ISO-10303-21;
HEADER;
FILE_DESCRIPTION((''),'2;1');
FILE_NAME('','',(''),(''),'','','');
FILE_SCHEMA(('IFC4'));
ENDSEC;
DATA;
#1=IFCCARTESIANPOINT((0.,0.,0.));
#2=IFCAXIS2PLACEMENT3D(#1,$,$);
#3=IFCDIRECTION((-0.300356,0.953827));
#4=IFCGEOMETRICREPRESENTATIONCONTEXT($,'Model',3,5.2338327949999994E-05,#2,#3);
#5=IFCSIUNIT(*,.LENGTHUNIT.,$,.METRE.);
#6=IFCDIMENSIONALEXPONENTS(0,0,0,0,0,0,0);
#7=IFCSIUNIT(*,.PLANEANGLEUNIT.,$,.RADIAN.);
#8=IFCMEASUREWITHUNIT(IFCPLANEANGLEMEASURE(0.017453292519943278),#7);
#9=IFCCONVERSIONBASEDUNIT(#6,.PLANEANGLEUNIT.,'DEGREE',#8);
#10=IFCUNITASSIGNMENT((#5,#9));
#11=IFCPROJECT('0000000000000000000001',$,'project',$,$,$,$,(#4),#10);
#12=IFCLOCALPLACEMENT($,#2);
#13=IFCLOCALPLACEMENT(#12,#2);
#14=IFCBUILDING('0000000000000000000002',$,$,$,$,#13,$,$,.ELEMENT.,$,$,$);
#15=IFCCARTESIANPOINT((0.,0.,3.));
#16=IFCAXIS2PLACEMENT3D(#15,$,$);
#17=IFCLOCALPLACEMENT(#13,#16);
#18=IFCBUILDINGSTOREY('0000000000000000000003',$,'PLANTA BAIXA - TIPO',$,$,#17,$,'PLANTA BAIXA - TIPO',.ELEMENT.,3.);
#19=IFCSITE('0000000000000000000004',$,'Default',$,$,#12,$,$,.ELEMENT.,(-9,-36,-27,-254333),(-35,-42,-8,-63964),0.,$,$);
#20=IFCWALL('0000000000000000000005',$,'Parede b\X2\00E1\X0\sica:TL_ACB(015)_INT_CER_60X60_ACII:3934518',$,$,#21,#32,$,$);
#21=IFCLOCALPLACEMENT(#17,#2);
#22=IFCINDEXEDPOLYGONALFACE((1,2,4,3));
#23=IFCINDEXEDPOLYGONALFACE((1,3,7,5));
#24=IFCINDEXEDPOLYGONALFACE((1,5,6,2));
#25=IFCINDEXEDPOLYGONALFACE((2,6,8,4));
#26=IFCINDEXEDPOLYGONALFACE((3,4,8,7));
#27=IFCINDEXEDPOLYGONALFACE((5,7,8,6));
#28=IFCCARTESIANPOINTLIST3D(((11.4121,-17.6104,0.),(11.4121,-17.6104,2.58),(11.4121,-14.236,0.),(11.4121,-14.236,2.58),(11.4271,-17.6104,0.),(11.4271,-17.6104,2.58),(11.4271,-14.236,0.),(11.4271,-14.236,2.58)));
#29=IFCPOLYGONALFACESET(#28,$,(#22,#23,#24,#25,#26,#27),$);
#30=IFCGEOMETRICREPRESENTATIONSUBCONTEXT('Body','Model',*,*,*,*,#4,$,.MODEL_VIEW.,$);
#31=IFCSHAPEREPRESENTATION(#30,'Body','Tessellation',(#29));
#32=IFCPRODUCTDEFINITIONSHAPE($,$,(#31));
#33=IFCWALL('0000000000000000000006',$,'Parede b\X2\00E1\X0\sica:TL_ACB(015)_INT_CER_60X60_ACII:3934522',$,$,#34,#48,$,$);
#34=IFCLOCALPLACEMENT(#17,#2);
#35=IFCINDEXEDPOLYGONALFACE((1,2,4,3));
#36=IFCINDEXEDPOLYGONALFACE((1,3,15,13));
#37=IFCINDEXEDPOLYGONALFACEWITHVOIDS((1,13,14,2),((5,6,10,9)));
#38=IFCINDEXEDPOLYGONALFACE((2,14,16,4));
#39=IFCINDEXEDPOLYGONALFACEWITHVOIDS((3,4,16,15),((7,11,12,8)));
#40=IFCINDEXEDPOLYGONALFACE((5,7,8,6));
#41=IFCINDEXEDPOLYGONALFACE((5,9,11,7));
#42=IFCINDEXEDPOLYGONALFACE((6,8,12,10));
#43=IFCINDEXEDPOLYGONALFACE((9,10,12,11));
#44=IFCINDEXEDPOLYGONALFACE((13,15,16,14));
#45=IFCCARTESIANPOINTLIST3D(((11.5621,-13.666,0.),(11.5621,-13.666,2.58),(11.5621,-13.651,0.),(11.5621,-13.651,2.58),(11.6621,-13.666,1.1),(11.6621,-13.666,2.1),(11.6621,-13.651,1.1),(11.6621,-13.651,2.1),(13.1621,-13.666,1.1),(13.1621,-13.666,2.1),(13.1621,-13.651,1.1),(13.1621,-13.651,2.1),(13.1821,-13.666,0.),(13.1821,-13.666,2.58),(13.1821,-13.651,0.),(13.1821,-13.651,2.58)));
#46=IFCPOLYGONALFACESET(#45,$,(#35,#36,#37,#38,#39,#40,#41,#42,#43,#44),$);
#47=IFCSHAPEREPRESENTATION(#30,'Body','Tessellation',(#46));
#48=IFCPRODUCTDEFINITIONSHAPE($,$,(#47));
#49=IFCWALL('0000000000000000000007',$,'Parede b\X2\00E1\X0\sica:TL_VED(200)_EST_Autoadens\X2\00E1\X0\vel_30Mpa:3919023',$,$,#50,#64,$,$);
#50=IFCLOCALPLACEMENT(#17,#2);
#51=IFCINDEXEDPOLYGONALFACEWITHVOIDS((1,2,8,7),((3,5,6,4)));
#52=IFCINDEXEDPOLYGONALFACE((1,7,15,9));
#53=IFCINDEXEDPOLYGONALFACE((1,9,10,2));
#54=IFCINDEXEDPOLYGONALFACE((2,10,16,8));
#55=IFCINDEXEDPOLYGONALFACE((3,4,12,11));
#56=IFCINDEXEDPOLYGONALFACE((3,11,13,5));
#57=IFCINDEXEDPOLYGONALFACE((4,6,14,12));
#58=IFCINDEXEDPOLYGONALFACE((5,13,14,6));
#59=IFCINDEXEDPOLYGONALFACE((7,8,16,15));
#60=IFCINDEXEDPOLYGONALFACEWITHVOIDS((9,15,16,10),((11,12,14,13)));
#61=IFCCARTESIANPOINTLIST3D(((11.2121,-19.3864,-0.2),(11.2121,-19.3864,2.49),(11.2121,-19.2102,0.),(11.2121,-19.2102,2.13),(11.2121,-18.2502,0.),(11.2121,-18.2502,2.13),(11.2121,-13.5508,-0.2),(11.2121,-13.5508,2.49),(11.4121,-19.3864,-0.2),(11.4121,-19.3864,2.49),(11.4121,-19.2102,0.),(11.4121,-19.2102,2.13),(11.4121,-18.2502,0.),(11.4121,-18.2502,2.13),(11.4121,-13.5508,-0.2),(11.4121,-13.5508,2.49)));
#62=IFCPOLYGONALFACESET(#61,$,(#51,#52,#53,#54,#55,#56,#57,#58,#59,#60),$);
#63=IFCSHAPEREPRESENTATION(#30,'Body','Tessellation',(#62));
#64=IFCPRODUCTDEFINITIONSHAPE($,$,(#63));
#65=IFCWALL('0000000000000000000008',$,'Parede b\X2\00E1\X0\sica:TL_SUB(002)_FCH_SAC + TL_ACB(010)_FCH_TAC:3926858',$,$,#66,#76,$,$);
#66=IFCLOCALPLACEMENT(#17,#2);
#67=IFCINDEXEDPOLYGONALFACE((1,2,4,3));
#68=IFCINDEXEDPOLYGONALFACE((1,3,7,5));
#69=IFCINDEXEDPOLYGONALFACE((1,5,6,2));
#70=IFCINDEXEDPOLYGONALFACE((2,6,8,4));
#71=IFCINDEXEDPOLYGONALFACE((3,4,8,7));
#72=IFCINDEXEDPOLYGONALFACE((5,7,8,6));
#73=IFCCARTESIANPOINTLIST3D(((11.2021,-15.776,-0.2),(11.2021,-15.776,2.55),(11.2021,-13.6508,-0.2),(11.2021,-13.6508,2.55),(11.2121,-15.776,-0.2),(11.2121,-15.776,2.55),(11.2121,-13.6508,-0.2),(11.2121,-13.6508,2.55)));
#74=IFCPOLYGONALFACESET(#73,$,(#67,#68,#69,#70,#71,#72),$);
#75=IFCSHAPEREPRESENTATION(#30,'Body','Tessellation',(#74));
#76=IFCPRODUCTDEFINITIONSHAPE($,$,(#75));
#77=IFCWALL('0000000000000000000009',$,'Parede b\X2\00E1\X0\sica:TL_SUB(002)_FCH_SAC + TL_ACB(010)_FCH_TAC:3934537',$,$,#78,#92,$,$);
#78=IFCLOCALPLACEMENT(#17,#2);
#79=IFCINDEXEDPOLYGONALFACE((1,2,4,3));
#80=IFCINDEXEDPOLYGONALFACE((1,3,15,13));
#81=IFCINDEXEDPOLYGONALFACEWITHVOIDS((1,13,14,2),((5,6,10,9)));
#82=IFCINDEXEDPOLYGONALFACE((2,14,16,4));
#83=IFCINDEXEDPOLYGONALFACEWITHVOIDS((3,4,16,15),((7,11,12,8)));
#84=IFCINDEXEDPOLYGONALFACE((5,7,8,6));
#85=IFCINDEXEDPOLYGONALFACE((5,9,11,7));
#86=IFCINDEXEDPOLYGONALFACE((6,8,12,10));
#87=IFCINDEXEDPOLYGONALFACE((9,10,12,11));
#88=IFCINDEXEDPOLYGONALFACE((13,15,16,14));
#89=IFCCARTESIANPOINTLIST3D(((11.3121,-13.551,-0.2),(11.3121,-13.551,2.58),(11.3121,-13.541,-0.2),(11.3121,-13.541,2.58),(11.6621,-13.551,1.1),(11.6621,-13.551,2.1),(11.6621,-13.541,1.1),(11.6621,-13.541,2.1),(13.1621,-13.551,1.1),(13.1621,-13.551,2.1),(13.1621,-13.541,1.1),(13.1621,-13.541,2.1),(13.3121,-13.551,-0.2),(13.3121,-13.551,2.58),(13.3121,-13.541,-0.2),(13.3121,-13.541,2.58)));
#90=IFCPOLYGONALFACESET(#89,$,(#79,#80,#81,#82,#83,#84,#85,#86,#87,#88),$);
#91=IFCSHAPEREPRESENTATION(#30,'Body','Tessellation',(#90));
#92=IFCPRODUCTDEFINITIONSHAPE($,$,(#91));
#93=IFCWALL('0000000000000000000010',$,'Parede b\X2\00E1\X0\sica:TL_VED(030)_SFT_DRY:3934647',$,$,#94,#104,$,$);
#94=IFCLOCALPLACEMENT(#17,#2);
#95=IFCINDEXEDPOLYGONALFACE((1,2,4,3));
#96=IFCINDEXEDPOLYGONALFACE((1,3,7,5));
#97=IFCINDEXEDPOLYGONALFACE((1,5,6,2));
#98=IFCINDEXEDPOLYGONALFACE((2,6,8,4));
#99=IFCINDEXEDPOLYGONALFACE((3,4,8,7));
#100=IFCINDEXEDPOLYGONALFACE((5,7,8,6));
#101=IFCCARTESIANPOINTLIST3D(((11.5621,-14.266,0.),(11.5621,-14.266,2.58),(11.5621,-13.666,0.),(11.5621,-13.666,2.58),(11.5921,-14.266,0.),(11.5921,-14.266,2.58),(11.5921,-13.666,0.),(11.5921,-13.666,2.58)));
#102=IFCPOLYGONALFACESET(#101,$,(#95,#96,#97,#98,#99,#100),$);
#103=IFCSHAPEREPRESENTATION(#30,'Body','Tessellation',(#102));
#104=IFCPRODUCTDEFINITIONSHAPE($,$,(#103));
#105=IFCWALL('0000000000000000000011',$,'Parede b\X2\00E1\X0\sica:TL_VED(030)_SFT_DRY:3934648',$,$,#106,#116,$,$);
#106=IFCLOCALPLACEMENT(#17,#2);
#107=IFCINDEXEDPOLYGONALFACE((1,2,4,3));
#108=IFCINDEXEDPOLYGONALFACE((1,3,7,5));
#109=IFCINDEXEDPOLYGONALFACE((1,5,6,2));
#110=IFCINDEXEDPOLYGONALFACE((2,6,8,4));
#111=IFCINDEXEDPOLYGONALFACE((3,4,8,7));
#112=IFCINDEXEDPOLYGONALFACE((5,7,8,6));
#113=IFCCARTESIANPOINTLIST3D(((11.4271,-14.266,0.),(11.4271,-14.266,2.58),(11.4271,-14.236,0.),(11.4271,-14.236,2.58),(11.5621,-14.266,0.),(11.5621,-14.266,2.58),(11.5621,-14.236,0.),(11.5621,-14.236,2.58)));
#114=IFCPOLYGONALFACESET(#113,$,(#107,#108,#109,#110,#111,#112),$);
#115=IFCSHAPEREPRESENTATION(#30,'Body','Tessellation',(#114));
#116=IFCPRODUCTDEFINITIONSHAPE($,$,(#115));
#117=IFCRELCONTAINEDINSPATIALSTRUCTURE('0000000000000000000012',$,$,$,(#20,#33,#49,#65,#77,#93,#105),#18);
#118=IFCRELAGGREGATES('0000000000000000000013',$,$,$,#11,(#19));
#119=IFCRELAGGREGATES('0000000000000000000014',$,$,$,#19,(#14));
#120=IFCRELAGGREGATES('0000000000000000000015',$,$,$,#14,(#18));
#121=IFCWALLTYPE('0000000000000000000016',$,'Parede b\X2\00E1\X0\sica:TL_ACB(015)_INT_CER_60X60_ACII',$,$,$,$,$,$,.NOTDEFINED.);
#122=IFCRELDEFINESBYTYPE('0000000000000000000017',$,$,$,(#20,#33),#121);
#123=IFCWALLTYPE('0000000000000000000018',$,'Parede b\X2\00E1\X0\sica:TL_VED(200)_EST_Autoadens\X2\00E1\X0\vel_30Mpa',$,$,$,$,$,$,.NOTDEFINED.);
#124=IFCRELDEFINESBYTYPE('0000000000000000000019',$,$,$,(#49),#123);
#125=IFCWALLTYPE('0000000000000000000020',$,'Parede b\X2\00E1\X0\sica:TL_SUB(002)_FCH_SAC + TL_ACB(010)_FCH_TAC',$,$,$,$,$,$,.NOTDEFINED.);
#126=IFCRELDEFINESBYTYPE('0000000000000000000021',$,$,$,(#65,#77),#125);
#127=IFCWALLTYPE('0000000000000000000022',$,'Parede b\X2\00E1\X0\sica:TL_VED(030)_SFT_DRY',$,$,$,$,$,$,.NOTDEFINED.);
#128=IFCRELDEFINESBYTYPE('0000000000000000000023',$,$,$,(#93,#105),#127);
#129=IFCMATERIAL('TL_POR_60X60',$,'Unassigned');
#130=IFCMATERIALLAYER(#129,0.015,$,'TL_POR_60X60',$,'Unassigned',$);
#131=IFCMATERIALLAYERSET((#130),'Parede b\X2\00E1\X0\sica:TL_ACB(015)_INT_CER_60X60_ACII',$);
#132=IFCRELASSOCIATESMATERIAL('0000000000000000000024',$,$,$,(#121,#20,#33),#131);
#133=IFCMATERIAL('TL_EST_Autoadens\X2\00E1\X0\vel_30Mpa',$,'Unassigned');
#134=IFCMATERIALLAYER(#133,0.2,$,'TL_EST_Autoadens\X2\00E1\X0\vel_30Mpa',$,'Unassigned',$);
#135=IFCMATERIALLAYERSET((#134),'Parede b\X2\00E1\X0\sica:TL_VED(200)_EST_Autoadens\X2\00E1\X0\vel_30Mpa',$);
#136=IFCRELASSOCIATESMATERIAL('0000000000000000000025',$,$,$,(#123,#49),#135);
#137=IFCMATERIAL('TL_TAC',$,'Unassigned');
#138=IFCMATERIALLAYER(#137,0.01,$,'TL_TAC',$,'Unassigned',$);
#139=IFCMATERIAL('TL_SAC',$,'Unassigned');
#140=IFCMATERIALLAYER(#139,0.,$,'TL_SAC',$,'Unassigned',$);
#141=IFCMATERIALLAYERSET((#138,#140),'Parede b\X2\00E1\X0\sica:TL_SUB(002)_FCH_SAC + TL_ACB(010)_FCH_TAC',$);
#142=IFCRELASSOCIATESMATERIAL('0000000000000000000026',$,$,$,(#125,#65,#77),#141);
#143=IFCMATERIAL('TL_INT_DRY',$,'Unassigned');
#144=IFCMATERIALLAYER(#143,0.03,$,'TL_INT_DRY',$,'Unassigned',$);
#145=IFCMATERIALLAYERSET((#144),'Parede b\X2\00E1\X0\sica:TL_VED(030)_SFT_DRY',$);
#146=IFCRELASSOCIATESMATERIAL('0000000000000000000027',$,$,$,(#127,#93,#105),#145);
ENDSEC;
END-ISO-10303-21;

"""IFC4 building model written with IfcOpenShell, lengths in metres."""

from ifc_helpers import new_model, entity, si_unit, converted_unit, direction, frame, frame_2d, origin, place, context, subcontext, project, spatial, rectangle, extrude, material, layer, layer_set, layer_usage, type_object, element, save


model = new_model("IFC4")

# Units and contexts
model_context = context("Model", 3, precision=5.2338327949999994e-05, world=origin(), true_north=direction((-0.300356, 0.953827)))
body_context = subcontext(model_context, "Body", "Model", "MODEL_VIEW")
ifc_project = project(units=[si_unit("LENGTHUNIT", "METRE"), converted_unit("PLANEANGLEUNIT", "DEGREE", entity("IfcPlaneAngleMeasure", 0.017453292519943278), si_unit("PLANEANGLEUNIT", "RADIAN"), dimensions=[0, 0, 0, 0, 0, 0, 0])], contexts=[model_context])

# Site, building, storey
site_placement = place(None, origin())
site = spatial("IfcSite", under=ifc_project, at=site_placement, Name="Default", CompositionType="ELEMENT", RefLatitude=(-9, -36, -27, -254333), RefLongitude=(-35, -42, -8, -63964), RefElevation=0.0)
building_placement = place(site_placement, origin())
building = spatial("IfcBuilding", under=site, at=building_placement, CompositionType="ELEMENT")
storey_placement = place(building_placement, frame((0.0, 0.0, 3.0)))
storey = spatial("IfcBuildingStorey", under=building, at=storey_placement, Name="PLANTA BAIXA - TIPO", LongName="PLANTA BAIXA - TIPO", CompositionType="ELEMENT", Elevation=3.0)

# Shared definitions
ifc_material_1 = material(Name="TL_POR_60X60", Category="Unassigned")

# Shared definitions
ifc_material_2 = material(Name="TL_EST_Autoadensável_30Mpa", Category="Unassigned")
ifc_material_3 = material(Name="TL_SAC", Category="Unassigned")

# Wall
ifc_layer_1 = layer(ifc_material_1, 0.015, Name="TL_POR_60X60", Category="Unassigned")
ifc_layer_set_1 = layer_set([ifc_layer_1], Name="Parede básica:TL_ACB(015)_INT_CER_60X60_ACII")
ifc_layer_usage_1 = layer_usage(ifc_layer_set_1, "AXIS2", "POSITIVE", -0.0075)
wall_type_1 = type_object("IfcWallType", Name="Parede básica:TL_ACB(015)_INT_CER_60X60_ACII", PredefinedType="NOTDEFINED", material=ifc_layer_set_1)
wall_1_placement = place(storey_placement, frame((11.4196, -17.6104, 0.0), z_axis=(0.0, 0.0, 1.0), x_axis=(0.0, 1.0, 0.0)))
element("IfcWall", 1, at=wall_1_placement, inside=storey, type_object=wall_type_1, material=ifc_layer_usage_1, Name="Parede básica:TL_ACB(015)_INT_CER_60X60_ACII:3934518", context=body_context, shape_type="SweptSolid", body=[
    extrude(rectangle(XDim=3.3744, YDim=0.015, at=frame_2d((1.6872, 0.0), x_axis=(-1.0, 0.0))), origin(), (0.0, 0.0, 1.0), 2.58),
])

# Walls, openings
ifc_layer_usage_2 = layer_usage(ifc_layer_set_1, "AXIS2", "POSITIVE", -0.0075)
wall_2_placement = place(storey_placement, frame((11.5621, -13.6585, 0.0)))
wall_2 = element("IfcWall", 2, at=wall_2_placement, inside=storey, type_object=wall_type_1, material=ifc_layer_usage_2, Name="Parede básica:TL_ACB(015)_INT_CER_60X60_ACII:3934522", context=body_context, shape_type="SweptSolid", body=[
    extrude(rectangle(XDim=1.62, YDim=0.015, at=frame_2d((0.81, 0.0), x_axis=(-1.0, 0.0))), origin(), (0.0, 0.0, 1.0), 2.58),
])
opening_1_placement = place(wall_2_placement, frame((-11.5621, 13.6585, 1.1)))
element("IfcOpeningElement", 3, at=opening_1_placement, cuts=wall_2, PredefinedType="OPENING", context=body_context, shape_type="SweptSolid", body=[
    extrude(rectangle(XDim=1.0, YDim=1.5, at=frame_2d((0.0, 0.0), x_axis=(0.0, 1.0))), frame((12.4121, -15.175, 0.5), z_axis=(0.0, 1.0, 0.0), x_axis=(1.0, 0.0, 0.0)), (0.0, 0.0, 1.0), 3.048),
])
ifc_layer_2 = layer(ifc_material_2, 0.2, Name="TL_EST_Autoadensável_30Mpa", Category="Unassigned")
ifc_layer_set_2 = layer_set([ifc_layer_2], Name="Parede básica:TL_VED(200)_EST_Autoadensável_30Mpa")
ifc_layer_usage_3 = layer_usage(ifc_layer_set_2, "AXIS2", "POSITIVE", -0.1)
wall_type_2 = type_object("IfcWallType", Name="Parede básica:TL_VED(200)_EST_Autoadensável_30Mpa", PredefinedType="NOTDEFINED", material=ifc_layer_set_2)
wall_3_placement = place(storey_placement, frame((11.3121, -13.5508, -0.2), z_axis=(0.0, 0.0, 1.0), x_axis=(0.0, -1.0, 0.0)))
wall_3 = element("IfcWall", 4, at=wall_3_placement, inside=storey, type_object=wall_type_2, material=ifc_layer_usage_3, Name="Parede básica:TL_VED(200)_EST_Autoadensável_30Mpa:3919023", context=body_context, shape_type="SweptSolid", body=[
    extrude(rectangle(XDim=5.8355, YDim=0.2, at=frame_2d((2.9178, 0.0), x_axis=(-1.0, 0.0))), origin(), (0.0, 0.0, 1.0), 2.69),
])
opening_2_placement = place(wall_3_placement, frame((4.6993, -0.1, 0.2)))
element("IfcOpeningElement", 5, at=opening_2_placement, cuts=wall_3, PredefinedType="OPENING", context=body_context, shape_type="SweptSolid", body=[
    extrude(rectangle(XDim=2.13, YDim=0.96, at=frame_2d((1.065, 0.48), x_axis=(1.0, 0.0))), frame((0.0, 0.0, 0.0), z_axis=(0.0, 1.0, 0.0), x_axis=(0.0, 0.0, 1.0)), (0.0, 0.0, 1.0), 0.2),
])

# Wall
ifc_material_4 = material(Name="TL_TAC", Category="Unassigned")
ifc_layer_3 = layer(ifc_material_4, 0.01, Name="TL_TAC", Category="Unassigned")
ifc_layer_4 = layer(ifc_material_3, 0.0, Name="TL_SAC", Category="Unassigned")
ifc_layer_set_3 = layer_set([ifc_layer_3, ifc_layer_4], Name="Parede básica:TL_SUB(002)_FCH_SAC + TL_ACB(010)_FCH_TAC")
ifc_layer_usage_4 = layer_usage(ifc_layer_set_3, "AXIS2", "NEGATIVE", 0.005)
wall_type_3 = type_object("IfcWallType", Name="Parede básica:TL_SUB(002)_FCH_SAC + TL_ACB(010)_FCH_TAC", PredefinedType="NOTDEFINED", material=ifc_layer_set_3)
wall_4_placement = place(storey_placement, frame((11.2071, -13.6508, -0.2), z_axis=(0.0, 0.0, 1.0), x_axis=(0.0, -1.0, 0.0)))
element("IfcWall", 6, at=wall_4_placement, inside=storey, type_object=wall_type_3, material=ifc_layer_usage_4, Name="Parede básica:TL_SUB(002)_FCH_SAC + TL_ACB(010)_FCH_TAC:3926858", context=body_context, shape_type="SweptSolid", body=[
    extrude(rectangle(XDim=2.1251, YDim=0.01, at=frame_2d((1.0626, 0.0), x_axis=(-1.0, 0.0))), origin(), (0.0, 0.0, 1.0), 2.75),
])

# Wall, opening
ifc_layer_usage_5 = layer_usage(ifc_layer_set_3, "AXIS2", "POSITIVE", -0.005)
wall_5_placement = place(storey_placement, frame((11.3121, -13.546, -0.2)))
wall_5 = element("IfcWall", 7, at=wall_5_placement, inside=storey, type_object=wall_type_3, material=ifc_layer_usage_5, Name="Parede básica:TL_SUB(002)_FCH_SAC + TL_ACB(010)_FCH_TAC:3934537", context=body_context, shape_type="SweptSolid", body=[
    extrude(rectangle(XDim=2.0, YDim=0.01, at=frame_2d((1.0, 0.0), x_axis=(-1.0, 0.0))), origin(), (0.0, 0.0, 1.0), 2.78),
])
opening_3_placement = place(wall_5_placement, frame((-11.3121, 13.546, 1.3)))
element("IfcOpeningElement", 8, at=opening_3_placement, cuts=wall_5, PredefinedType="OPENING", context=body_context, shape_type="SweptSolid", body=[
    extrude(rectangle(XDim=1.0, YDim=1.5, at=frame_2d((0.0, 0.0), x_axis=(0.0, 1.0))), frame((12.4121, -15.175, 0.5), z_axis=(0.0, 1.0, 0.0), x_axis=(1.0, 0.0, 0.0)), (0.0, 0.0, 1.0), 3.048),
])

# Walls
ifc_material_5 = material(Name="TL_INT_DRY", Category="Unassigned")
ifc_layer_5 = layer(ifc_material_5, 0.03, Name="TL_INT_DRY", Category="Unassigned")
ifc_layer_set_4 = layer_set([ifc_layer_5], Name="Parede básica:TL_VED(030)_SFT_DRY")
ifc_layer_usage_6 = layer_usage(ifc_layer_set_4, "AXIS2", "NEGATIVE", 0.015)
wall_type_4 = type_object("IfcWallType", Name="Parede básica:TL_VED(030)_SFT_DRY", PredefinedType="NOTDEFINED", material=ifc_layer_set_4)
wall_6_placement = place(storey_placement, frame((11.5771, -13.666, 0.0), z_axis=(0.0, 0.0, 1.0), x_axis=(0.0, -1.0, 0.0)))
element("IfcWall", 9, at=wall_6_placement, inside=storey, type_object=wall_type_4, material=ifc_layer_usage_6, Name="Parede básica:TL_VED(030)_SFT_DRY:3934647", context=body_context, shape_type="SweptSolid", body=[
    extrude(rectangle(XDim=0.6, YDim=0.03, at=frame_2d((0.3, 0.0), x_axis=(-1.0, 0.0))), origin(), (0.0, 0.0, 1.0), 2.58),
])
ifc_layer_usage_7 = layer_usage(ifc_layer_set_4, "AXIS2", "NEGATIVE", 0.015)
wall_7_placement = place(storey_placement, frame((11.5621, -14.251, 0.0), z_axis=(0.0, 0.0, 1.0), x_axis=(-1.0, 0.0, 0.0)))
element("IfcWall", 10, at=wall_7_placement, inside=storey, type_object=wall_type_4, material=ifc_layer_usage_7, Name="Parede básica:TL_VED(030)_SFT_DRY:3934648", context=body_context, shape_type="SweptSolid", body=[
    extrude(rectangle(XDim=0.135, YDim=0.03, at=frame_2d((0.0675, 0.0), x_axis=(-1.0, 0.0))), origin(), (0.0, 0.0, 1.0), 2.58),
])

save(model, "model.ifc")
